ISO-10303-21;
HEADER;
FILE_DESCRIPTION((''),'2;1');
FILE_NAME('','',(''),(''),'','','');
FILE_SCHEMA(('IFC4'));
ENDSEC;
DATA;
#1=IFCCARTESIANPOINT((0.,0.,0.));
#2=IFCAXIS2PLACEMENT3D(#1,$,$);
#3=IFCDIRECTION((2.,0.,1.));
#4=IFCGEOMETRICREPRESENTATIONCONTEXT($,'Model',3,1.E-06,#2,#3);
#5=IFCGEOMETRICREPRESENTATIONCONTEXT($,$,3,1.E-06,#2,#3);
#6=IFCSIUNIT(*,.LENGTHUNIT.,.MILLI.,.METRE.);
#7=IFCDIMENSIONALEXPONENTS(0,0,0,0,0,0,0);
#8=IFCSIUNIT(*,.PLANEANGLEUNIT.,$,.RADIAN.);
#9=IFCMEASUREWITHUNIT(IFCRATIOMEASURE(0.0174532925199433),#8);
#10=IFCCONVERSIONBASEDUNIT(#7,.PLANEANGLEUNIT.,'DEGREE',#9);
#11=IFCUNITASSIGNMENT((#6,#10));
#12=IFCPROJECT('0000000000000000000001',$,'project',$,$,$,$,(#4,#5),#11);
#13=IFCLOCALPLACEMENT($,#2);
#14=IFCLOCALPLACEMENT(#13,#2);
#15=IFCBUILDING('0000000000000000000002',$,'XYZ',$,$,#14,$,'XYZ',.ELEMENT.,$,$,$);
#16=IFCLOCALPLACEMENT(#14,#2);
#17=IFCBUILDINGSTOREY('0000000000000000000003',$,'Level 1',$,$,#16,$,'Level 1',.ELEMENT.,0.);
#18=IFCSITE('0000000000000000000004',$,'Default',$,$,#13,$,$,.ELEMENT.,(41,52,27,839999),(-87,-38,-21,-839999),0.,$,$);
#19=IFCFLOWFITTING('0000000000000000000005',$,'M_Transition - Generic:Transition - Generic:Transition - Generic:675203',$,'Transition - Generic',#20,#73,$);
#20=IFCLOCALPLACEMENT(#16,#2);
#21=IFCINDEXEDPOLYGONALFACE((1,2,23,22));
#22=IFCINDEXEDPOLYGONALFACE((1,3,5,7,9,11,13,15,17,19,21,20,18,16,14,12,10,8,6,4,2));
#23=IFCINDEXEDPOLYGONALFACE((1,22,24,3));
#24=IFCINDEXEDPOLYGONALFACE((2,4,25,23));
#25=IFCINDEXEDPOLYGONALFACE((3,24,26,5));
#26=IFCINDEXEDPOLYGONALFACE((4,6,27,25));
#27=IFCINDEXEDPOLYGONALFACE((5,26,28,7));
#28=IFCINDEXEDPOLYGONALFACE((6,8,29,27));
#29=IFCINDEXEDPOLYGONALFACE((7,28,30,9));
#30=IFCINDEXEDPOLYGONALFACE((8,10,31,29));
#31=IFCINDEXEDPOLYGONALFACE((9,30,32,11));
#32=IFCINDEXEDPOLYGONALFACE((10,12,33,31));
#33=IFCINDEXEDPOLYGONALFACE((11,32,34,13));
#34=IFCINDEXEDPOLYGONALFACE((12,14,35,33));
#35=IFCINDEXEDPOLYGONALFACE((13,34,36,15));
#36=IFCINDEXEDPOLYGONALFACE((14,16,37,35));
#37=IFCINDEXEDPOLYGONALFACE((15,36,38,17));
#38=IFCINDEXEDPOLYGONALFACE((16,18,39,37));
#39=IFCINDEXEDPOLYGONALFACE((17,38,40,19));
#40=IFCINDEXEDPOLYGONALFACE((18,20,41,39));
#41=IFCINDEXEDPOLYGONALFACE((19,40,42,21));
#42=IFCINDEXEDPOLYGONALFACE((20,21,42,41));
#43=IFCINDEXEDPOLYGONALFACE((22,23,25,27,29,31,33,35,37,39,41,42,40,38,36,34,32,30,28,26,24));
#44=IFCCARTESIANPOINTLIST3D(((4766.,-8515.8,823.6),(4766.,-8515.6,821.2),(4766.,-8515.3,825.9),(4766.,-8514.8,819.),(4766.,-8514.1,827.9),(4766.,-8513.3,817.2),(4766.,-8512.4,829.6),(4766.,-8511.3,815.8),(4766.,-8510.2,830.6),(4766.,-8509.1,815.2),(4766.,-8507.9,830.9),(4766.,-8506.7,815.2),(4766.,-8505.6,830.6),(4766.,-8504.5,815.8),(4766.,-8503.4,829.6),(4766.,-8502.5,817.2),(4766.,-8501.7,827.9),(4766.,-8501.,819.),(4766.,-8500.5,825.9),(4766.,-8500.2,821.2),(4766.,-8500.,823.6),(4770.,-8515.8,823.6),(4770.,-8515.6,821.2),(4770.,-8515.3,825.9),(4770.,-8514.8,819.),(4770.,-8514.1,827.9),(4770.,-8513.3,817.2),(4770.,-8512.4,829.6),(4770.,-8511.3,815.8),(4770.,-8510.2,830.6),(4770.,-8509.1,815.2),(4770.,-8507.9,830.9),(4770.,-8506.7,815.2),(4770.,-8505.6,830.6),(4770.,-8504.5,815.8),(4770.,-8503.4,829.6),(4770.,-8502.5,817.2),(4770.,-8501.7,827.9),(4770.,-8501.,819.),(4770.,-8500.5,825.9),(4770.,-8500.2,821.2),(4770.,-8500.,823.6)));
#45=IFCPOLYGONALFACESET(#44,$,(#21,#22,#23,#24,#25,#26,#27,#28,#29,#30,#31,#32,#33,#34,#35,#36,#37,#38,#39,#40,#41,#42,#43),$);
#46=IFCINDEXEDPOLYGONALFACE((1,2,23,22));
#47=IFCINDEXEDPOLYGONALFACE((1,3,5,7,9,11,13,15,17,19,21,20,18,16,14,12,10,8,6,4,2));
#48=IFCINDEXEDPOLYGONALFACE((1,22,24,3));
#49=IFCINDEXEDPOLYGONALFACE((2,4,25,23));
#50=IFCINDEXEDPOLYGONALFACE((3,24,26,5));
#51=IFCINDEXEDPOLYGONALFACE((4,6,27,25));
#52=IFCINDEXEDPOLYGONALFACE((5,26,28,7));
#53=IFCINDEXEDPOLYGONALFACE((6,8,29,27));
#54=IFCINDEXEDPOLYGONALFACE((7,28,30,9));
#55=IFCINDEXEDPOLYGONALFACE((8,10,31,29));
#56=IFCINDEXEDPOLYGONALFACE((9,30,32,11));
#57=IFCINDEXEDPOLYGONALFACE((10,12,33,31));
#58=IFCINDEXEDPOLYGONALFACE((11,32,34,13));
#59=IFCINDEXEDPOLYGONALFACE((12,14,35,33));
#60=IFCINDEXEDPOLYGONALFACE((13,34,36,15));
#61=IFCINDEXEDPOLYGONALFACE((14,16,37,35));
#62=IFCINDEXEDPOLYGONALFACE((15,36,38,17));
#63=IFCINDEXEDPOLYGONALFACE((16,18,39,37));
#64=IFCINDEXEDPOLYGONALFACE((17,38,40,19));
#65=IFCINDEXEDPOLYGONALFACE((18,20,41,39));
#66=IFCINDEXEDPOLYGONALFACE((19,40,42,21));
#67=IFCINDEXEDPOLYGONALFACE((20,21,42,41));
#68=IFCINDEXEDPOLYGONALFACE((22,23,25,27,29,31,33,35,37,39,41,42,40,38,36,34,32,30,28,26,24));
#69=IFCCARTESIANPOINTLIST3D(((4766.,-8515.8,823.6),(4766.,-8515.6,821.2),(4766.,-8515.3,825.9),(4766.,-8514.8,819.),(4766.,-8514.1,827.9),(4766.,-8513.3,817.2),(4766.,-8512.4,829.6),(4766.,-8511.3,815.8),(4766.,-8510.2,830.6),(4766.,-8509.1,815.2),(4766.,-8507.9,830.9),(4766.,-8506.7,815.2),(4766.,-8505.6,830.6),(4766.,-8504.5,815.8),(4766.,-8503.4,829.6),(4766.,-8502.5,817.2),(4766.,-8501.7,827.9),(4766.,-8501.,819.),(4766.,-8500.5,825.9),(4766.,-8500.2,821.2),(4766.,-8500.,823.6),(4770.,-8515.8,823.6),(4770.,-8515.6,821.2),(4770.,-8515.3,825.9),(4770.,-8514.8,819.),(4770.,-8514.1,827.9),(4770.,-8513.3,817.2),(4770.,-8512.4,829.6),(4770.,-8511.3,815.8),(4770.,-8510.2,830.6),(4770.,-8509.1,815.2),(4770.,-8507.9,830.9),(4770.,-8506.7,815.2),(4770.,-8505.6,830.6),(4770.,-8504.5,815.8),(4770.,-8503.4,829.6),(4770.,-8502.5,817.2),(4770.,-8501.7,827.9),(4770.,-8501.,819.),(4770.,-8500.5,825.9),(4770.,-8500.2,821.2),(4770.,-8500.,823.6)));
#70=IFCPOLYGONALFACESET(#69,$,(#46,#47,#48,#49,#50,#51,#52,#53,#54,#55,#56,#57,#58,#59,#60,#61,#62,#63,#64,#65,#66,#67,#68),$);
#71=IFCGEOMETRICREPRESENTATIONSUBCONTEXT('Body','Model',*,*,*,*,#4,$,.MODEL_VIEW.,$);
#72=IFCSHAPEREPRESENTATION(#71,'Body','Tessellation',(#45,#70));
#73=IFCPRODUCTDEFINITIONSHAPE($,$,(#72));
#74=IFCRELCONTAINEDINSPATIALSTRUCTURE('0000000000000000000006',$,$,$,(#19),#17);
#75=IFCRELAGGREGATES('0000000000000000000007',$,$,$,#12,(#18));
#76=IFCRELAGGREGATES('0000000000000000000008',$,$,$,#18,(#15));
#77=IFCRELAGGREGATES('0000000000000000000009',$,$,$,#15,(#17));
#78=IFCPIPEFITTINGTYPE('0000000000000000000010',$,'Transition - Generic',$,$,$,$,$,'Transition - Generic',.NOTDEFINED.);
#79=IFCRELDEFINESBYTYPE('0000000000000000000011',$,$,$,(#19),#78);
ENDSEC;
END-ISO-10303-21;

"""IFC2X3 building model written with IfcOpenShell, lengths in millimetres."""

from ifc_helpers import new_model, entity, si_unit, converted_unit, direction, frame, frame_2d, origin, place, context, subcontext, project, spatial, circle, extrude, source, transform, mapped, type_object, type_shapes, element, save


model = new_model("IFC2X3")

# Units and contexts
model_context = context("Model", 3, precision=1e-06, world=origin(), true_north=direction((2.0, 0.0, 1.0)))
context_of_model = context(None, 3, precision=1e-06, world=origin(), true_north=direction((2.0, 0.0, 1.0)))
body_context = subcontext(model_context, "Body", "Model", "MODEL_VIEW")
ifc_project = project(units=[si_unit("LENGTHUNIT", "METRE", prefix="MILLI"), converted_unit("PLANEANGLEUNIT", "DEGREE", entity("IfcRatioMeasure", 0.0174532925199433), si_unit("PLANEANGLEUNIT", "RADIAN"), dimensions=[0, 0, 0, 0, 0, 0, 0])], contexts=[model_context, context_of_model])

# Site, building, storey
site_placement = place(None, origin())
site = spatial("IfcSite", under=ifc_project, at=site_placement, Name="Default", CompositionType="ELEMENT", RefLatitude=(41, 52, 27, 839999), RefLongitude=(-87, -38, -21, -839999), RefElevation=0.0)
building_placement = place(site_placement, origin())
building = spatial("IfcBuilding", under=site, at=building_placement, Name="XYZ", LongName="XYZ", CompositionType="ELEMENT")
storey_placement = place(building_placement, origin())
storey = spatial("IfcBuildingStorey", under=building, at=storey_placement, Name="Level 1", LongName="Level 1", CompositionType="ELEMENT", Elevation=0.0)

# Flow fitting
pipe_fitting_type = type_object("IfcPipeFittingType", Name="Transition - Generic", ElementType="Transition - Generic", PredefinedType="NOTDEFINED")
shared_shape = source(origin(), body_context, "Body", "SweptSolid", [
    extrude(circle(Radius=7.9, at=frame_2d((0.0, 0.0), x_axis=(1.0, 0.0))), frame((0.0, 0.0, 0.0), z_axis=(1.0, 0.0, 0.0), x_axis=(0.0, 0.0, 1.0)), (0.0, 0.0, 1.0), 4.0),
    extrude(circle(Radius=7.9, at=frame_2d((0.0, 0.0), x_axis=(1.0, 0.0))), frame((0.0, 0.0, 0.0), z_axis=(1.0, 0.0, 0.0), x_axis=(0.0, 0.0, 1.0)), (0.0, 0.0, 1.0), 4.0),
])
type_shapes(pipe_fitting_type, [shared_shape])
for number, where, name in (
    (1, (4766.0, -8507.9, 823.0), "M_Transition - Generic:Transition - Generic:Transition - Generic:675203"),
):
    element("IfcFlowFitting", number, at=place(storey_placement, frame(where)), inside=storey, type_object=pipe_fitting_type, Name=name, ObjectType="Transition - Generic", context=body_context, shape_type="MappedRepresentation", body=[
        mapped(shared_shape, transform((0.0, 0.0, 0.0), scale=1.0)),
    ])

save(model, "model.ifc")
